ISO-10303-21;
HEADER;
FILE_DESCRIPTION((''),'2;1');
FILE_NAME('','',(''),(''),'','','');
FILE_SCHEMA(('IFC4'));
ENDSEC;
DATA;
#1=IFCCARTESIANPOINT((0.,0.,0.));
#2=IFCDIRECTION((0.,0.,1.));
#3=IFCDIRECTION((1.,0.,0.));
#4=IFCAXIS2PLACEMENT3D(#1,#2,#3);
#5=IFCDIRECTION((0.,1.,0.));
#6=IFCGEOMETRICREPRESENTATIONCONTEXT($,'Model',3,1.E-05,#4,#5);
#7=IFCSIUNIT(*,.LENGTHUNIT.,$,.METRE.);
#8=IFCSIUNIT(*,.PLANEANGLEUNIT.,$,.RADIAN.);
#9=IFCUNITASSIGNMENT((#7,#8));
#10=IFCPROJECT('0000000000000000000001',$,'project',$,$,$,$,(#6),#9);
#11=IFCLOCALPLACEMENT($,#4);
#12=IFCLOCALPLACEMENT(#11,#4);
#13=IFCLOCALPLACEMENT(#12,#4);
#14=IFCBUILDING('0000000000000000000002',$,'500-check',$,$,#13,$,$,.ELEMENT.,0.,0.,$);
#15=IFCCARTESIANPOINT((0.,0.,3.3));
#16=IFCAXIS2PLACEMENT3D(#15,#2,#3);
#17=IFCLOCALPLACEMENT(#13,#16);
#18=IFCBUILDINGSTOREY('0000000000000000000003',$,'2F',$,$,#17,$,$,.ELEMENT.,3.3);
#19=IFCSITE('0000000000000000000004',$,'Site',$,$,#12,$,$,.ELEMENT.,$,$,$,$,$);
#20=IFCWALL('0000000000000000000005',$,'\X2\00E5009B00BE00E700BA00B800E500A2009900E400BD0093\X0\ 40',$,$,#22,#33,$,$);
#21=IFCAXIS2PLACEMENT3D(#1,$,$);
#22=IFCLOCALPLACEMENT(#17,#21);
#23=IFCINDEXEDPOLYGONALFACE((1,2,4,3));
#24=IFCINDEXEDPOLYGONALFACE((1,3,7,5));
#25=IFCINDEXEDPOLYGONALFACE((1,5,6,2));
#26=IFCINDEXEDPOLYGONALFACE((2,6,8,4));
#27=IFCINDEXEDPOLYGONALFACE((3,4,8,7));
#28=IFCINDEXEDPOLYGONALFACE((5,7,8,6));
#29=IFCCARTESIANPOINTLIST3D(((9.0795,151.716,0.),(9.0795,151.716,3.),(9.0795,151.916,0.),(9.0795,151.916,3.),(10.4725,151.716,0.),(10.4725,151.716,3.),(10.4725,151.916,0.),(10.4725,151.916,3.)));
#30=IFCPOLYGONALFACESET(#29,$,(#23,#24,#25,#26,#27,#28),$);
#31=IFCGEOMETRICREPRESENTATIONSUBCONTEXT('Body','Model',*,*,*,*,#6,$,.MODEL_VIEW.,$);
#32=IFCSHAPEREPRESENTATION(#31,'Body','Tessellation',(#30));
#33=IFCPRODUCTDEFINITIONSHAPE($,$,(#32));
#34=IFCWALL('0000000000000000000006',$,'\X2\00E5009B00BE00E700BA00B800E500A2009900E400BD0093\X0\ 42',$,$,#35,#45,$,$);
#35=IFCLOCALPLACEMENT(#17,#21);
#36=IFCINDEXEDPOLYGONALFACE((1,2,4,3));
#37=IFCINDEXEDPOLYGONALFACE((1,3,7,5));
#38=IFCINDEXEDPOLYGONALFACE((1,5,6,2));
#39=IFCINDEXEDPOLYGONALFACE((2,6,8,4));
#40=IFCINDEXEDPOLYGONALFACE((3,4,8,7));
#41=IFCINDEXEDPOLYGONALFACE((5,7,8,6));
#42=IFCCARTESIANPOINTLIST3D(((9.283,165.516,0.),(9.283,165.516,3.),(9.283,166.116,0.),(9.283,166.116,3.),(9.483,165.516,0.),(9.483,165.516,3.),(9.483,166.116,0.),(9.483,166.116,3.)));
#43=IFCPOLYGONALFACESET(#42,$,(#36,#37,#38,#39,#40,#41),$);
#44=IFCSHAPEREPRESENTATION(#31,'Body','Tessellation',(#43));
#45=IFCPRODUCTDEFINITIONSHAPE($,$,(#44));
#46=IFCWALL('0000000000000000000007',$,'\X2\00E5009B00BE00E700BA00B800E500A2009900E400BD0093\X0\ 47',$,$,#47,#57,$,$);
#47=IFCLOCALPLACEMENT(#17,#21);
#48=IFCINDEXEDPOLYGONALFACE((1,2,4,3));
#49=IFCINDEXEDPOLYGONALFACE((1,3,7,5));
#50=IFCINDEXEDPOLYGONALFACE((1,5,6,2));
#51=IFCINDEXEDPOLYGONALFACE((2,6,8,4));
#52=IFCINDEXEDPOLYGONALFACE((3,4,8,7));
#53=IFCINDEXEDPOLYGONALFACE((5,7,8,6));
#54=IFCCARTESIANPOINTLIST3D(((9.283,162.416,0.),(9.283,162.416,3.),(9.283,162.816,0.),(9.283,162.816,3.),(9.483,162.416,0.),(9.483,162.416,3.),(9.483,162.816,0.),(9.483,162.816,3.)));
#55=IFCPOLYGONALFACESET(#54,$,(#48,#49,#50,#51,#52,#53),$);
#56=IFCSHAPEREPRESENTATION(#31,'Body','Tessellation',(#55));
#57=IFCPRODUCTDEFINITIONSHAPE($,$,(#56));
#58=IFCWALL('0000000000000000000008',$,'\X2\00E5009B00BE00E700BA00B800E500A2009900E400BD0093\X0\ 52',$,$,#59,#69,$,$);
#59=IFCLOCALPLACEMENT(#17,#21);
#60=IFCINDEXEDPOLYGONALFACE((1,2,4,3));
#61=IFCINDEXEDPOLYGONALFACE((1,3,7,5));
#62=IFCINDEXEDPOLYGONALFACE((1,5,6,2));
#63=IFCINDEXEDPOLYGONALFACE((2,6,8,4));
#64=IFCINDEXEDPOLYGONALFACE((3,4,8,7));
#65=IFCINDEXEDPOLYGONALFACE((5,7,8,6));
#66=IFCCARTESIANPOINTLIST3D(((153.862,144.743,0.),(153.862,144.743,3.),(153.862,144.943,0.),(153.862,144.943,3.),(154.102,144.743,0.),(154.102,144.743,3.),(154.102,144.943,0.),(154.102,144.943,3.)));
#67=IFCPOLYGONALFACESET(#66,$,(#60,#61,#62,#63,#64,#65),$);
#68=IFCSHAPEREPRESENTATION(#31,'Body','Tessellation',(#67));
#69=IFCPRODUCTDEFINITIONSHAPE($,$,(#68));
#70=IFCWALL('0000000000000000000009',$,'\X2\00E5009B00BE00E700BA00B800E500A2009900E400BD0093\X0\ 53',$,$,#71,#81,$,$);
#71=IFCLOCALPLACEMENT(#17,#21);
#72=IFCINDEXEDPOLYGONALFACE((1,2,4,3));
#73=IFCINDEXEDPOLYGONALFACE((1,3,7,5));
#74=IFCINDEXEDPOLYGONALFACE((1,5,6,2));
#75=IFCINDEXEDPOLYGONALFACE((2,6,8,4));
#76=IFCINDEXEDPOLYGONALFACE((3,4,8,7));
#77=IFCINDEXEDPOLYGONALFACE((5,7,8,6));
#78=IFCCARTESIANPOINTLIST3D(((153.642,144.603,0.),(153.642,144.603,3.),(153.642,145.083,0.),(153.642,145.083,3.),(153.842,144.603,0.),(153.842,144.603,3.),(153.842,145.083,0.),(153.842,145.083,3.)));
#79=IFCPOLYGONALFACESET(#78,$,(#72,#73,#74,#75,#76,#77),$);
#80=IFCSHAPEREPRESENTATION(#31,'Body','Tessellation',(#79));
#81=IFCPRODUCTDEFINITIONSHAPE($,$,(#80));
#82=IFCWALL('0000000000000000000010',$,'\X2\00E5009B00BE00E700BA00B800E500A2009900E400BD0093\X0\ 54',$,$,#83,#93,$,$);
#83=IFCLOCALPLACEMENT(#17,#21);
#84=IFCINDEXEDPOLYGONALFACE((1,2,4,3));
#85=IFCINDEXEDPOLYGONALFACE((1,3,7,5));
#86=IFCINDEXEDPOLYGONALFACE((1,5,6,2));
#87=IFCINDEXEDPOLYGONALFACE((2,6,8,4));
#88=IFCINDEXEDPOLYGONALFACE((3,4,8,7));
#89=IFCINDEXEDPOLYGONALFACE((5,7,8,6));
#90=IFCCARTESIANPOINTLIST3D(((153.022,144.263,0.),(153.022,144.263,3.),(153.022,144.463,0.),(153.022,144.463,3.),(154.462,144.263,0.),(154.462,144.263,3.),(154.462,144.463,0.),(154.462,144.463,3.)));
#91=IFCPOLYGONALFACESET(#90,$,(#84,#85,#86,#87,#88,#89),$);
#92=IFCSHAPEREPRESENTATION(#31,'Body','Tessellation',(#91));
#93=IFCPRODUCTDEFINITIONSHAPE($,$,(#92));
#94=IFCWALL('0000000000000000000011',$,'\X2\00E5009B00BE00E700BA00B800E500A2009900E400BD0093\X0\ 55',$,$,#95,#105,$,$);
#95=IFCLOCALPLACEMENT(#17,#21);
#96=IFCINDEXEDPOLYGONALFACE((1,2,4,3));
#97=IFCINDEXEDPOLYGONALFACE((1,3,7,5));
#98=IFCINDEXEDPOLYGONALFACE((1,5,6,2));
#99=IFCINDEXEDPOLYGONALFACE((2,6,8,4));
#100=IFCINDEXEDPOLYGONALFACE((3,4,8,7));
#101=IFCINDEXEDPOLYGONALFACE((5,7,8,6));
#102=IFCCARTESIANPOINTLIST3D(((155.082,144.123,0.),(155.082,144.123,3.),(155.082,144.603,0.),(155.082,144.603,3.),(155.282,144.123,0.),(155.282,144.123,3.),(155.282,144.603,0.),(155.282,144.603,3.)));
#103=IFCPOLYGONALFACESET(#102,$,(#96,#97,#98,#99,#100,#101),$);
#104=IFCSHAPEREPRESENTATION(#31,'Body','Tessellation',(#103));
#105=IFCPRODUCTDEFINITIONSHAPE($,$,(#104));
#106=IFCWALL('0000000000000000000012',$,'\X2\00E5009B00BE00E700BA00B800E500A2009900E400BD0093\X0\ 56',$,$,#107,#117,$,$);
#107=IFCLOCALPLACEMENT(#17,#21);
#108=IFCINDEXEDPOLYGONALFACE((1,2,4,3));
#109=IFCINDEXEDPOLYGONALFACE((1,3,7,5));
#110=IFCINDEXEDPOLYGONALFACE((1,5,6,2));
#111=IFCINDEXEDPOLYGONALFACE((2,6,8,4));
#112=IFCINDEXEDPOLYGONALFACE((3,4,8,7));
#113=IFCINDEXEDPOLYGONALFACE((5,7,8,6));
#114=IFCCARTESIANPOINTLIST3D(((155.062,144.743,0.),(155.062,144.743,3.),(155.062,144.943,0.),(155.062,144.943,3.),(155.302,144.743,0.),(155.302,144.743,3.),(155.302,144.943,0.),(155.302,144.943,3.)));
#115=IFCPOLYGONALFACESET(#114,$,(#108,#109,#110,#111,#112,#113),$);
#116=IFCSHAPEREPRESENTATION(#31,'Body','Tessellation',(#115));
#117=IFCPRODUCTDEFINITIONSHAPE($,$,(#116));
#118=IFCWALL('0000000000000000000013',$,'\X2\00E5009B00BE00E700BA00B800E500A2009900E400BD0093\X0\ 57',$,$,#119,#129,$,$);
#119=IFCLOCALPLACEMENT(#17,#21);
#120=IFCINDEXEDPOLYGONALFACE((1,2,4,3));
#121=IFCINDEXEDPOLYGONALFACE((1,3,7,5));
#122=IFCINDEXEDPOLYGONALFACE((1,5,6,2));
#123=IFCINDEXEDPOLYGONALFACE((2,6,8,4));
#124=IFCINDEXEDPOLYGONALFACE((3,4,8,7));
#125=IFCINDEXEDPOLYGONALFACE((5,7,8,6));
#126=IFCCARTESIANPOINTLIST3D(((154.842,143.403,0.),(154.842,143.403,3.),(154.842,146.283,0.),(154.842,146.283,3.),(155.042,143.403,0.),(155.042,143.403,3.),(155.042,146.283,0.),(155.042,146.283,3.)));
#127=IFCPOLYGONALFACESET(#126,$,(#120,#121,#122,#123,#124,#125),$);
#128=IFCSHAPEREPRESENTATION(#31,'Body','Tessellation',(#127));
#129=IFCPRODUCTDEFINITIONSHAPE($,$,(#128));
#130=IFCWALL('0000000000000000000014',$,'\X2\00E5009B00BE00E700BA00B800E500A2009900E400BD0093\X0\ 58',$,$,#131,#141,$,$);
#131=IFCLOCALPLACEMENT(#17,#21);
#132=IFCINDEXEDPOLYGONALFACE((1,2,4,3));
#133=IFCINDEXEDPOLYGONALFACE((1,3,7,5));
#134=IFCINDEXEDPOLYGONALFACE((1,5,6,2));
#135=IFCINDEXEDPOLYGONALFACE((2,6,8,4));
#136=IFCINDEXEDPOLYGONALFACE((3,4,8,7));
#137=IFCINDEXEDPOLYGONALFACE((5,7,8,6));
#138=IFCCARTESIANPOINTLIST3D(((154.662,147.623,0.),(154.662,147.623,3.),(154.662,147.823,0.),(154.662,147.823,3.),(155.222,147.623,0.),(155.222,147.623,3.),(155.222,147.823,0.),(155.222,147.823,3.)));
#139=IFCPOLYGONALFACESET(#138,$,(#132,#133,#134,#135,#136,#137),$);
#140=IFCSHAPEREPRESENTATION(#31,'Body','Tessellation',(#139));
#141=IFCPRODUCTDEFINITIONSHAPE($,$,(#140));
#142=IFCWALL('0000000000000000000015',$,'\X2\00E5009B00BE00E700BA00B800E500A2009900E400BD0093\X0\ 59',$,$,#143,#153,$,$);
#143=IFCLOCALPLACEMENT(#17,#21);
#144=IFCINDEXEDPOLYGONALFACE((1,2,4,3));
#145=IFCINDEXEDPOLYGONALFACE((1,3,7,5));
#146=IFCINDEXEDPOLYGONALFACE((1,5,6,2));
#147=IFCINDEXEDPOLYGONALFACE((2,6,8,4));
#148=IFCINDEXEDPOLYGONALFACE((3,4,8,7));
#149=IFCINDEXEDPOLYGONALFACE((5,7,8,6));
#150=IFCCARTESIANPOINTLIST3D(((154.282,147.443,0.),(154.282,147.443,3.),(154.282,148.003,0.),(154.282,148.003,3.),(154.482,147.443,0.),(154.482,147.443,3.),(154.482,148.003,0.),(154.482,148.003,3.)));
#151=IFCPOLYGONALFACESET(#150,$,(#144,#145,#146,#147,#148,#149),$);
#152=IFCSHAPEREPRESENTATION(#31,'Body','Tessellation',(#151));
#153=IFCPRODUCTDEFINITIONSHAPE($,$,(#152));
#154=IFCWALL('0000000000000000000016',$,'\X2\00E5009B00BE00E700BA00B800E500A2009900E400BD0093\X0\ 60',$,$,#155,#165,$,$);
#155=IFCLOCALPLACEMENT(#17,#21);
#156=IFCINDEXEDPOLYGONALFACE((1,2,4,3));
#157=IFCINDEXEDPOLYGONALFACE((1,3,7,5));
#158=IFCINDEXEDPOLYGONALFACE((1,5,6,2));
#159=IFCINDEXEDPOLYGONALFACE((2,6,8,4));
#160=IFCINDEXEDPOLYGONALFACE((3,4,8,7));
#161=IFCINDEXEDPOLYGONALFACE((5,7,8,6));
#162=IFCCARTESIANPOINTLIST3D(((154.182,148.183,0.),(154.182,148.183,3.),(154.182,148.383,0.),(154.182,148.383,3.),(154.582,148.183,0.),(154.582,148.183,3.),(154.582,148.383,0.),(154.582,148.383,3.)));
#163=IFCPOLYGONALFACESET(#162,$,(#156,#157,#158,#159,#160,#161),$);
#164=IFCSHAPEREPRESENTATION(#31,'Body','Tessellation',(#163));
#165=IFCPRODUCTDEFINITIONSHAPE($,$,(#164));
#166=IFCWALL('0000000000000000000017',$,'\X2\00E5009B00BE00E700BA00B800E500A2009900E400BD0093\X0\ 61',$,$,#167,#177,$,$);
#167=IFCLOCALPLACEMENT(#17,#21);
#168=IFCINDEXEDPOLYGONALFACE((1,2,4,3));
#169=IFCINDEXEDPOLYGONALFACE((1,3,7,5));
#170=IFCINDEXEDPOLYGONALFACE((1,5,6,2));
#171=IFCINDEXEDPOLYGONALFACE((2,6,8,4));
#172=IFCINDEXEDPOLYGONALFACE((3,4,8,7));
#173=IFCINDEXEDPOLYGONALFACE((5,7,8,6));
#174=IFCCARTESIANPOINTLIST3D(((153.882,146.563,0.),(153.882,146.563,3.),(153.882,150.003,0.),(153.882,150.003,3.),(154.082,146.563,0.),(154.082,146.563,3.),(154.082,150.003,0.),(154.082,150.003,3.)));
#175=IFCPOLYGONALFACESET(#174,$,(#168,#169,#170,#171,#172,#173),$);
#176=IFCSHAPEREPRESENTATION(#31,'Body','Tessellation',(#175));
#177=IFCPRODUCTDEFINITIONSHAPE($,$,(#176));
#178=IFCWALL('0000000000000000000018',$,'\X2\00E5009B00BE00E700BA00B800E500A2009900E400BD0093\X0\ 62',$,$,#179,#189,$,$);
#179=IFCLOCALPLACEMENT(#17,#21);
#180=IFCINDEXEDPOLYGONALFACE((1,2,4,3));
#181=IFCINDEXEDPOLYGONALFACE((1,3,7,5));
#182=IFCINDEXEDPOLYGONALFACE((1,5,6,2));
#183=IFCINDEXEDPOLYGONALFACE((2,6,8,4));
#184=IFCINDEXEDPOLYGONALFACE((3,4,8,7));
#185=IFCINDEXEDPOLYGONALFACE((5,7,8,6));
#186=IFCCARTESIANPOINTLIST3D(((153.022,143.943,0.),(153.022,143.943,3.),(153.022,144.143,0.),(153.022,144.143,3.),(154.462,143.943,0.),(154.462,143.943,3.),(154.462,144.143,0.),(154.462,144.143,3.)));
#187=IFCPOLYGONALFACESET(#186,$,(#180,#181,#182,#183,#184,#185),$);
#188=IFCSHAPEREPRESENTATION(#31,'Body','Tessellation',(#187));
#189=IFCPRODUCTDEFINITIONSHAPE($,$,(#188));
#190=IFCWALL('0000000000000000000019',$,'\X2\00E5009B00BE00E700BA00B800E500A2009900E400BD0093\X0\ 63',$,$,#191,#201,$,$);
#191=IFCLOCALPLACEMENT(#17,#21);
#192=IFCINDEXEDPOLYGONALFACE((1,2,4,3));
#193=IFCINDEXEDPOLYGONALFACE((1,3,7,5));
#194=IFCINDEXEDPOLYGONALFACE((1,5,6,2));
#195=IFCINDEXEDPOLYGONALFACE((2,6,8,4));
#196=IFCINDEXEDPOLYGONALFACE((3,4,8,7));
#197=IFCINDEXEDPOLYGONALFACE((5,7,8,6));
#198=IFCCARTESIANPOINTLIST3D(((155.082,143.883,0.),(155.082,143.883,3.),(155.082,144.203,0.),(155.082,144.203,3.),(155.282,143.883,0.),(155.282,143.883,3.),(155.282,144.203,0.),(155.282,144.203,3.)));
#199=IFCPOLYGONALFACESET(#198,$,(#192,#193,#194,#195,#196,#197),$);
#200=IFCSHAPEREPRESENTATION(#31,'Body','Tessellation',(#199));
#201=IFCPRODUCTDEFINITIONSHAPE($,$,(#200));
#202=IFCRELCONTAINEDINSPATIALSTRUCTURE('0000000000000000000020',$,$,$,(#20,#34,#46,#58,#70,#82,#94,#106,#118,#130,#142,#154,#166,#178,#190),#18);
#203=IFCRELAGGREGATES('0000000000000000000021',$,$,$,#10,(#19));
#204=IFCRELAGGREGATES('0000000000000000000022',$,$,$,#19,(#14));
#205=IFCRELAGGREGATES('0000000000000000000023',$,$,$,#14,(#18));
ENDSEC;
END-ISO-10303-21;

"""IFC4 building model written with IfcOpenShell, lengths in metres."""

from ifc_helpers import new_model, si_unit, direction, frame, frame_2d, origin_with_axes, place, context, subcontext, project, spatial, rectangle, extrude, element, save


model = new_model("IFC4")

# Units and contexts
model_context = context("Model", 3, precision=1e-05, world=origin_with_axes(), true_north=direction((0.0, 1.0, 0.0)))
body_context = subcontext(model_context, "Body", "Model", "MODEL_VIEW")
ifc_project = project(units=[si_unit("LENGTHUNIT", "METRE"), si_unit("PLANEANGLEUNIT", "RADIAN")], contexts=[model_context])

# Site, building, storey
placement = place(None, origin_with_axes())
site_placement = place(placement, origin_with_axes())
site = spatial("IfcSite", under=ifc_project, at=site_placement, Name="Site", CompositionType="ELEMENT")
building_placement = place(site_placement, origin_with_axes())
building = spatial("IfcBuilding", under=site, at=building_placement, Name="500-check", CompositionType="ELEMENT", ElevationOfRefHeight=0.0, ElevationOfTerrain=0.0)
storey_placement = place(building_placement, frame((0.0, 0.0, 3.3), z_axis=(0.0, 0.0, 1.0), x_axis=(1.0, 0.0, 0.0)))
storey = spatial("IfcBuildingStorey", under=building, at=storey_placement, Name="2F", CompositionType="ELEMENT", Elevation=3.3)

# Walls
wall_1_placement = place(storey_placement, frame((9.776, 151.816, 0.0), z_axis=(0.0, 0.0, 1.0), x_axis=(-1.0, 0.0, 0.0)))
element("IfcWall", 1, at=wall_1_placement, inside=storey, Name="å\u009b¾çº¸å¢\u0099ä½\u0093 40", context=body_context, shape_type="SweptSolid", body=[
    extrude(rectangle(XDim=1.393, YDim=0.2, at=frame_2d((0.0, 0.0), x_axis=(1.0, 0.0, 0.0))), frame((0.0, 0.0, 0.0), z_axis=(0.0, 0.0, 1.0)), (0.0, 0.0, 1.0), 3.0),
])
wall_2_placement = place(storey_placement, frame((9.383, 165.816, 0.0), z_axis=(0.0, 0.0, 1.0), x_axis=(0.0, 1.0, 0.0)))
element("IfcWall", 2, at=wall_2_placement, inside=storey, Name="å\u009b¾çº¸å¢\u0099ä½\u0093 42", context=body_context, shape_type="SweptSolid", body=[
    extrude(rectangle(XDim=0.6, YDim=0.2, at=frame_2d((0.0, 0.0), x_axis=(1.0, 0.0, 0.0))), frame((0.0, 0.0, 0.0), z_axis=(0.0, 0.0, 1.0)), (0.0, 0.0, 1.0), 3.0),
])
wall_3_placement = place(storey_placement, frame((9.383, 162.616, 0.0), z_axis=(0.0, 0.0, 1.0), x_axis=(0.0, -1.0, 0.0)))
element("IfcWall", 3, at=wall_3_placement, inside=storey, Name="å\u009b¾çº¸å¢\u0099ä½\u0093 47", context=body_context, shape_type="SweptSolid", body=[
    extrude(rectangle(XDim=0.4, YDim=0.2, at=frame_2d((0.0, 0.0), x_axis=(1.0, 0.0, 0.0))), frame((0.0, 0.0, 0.0), z_axis=(0.0, 0.0, 1.0)), (0.0, 0.0, 1.0), 3.0),
])
wall_4_placement = place(storey_placement, frame((153.982, 144.843, 0.0), z_axis=(0.0, 0.0, 1.0), x_axis=(-1.0, 0.0, 0.0)))
element("IfcWall", 4, at=wall_4_placement, inside=storey, Name="å\u009b¾çº¸å¢\u0099ä½\u0093 52", context=body_context, shape_type="SweptSolid", body=[
    extrude(rectangle(XDim=0.24, YDim=0.2, at=frame_2d((0.0, 0.0), x_axis=(1.0, 0.0, 0.0))), frame((0.0, 0.0, 0.0), z_axis=(0.0, 0.0, 1.0)), (0.0, 0.0, 1.0), 3.0),
])
wall_5_placement = place(storey_placement, frame((153.742, 144.843, 0.0), z_axis=(0.0, 0.0, 1.0), x_axis=(0.0, -1.0, 0.0)))
element("IfcWall", 5, at=wall_5_placement, inside=storey, Name="å\u009b¾çº¸å¢\u0099ä½\u0093 53", context=body_context, shape_type="SweptSolid", body=[
    extrude(rectangle(XDim=0.48, YDim=0.2, at=frame_2d((0.0, 0.0), x_axis=(1.0, 0.0, 0.0))), frame((0.0, 0.0, 0.0), z_axis=(0.0, 0.0, 1.0)), (0.0, 0.0, 1.0), 3.0),
])
wall_6_placement = place(storey_placement, frame((153.742, 144.363, 0.0), z_axis=(0.0, 0.0, 1.0), x_axis=(1.0, 0.0, 0.0)))
element("IfcWall", 6, at=wall_6_placement, inside=storey, Name="å\u009b¾çº¸å¢\u0099ä½\u0093 54", context=body_context, shape_type="SweptSolid", body=[
    extrude(rectangle(XDim=1.44, YDim=0.2, at=frame_2d((0.0, 0.0), x_axis=(1.0, 0.0, 0.0))), frame((0.0, 0.0, 0.0), z_axis=(0.0, 0.0, 1.0)), (0.0, 0.0, 1.0), 3.0),
])
wall_7_placement = place(storey_placement, frame((155.182, 144.363, 0.0), z_axis=(0.0, 0.0, 1.0), x_axis=(0.0, 1.0, 0.0)))
element("IfcWall", 7, at=wall_7_placement, inside=storey, Name="å\u009b¾çº¸å¢\u0099ä½\u0093 55", context=body_context, shape_type="SweptSolid", body=[
    extrude(rectangle(XDim=0.48, YDim=0.2, at=frame_2d((0.0, 0.0), x_axis=(1.0, 0.0, 0.0))), frame((0.0, 0.0, 0.0), z_axis=(0.0, 0.0, 1.0)), (0.0, 0.0, 1.0), 3.0),
])
wall_8_placement = place(storey_placement, frame((155.182, 144.843, 0.0), z_axis=(0.0, 0.0, 1.0), x_axis=(-1.0, 0.0, 0.0)))
element("IfcWall", 8, at=wall_8_placement, inside=storey, Name="å\u009b¾çº¸å¢\u0099ä½\u0093 56", context=body_context, shape_type="SweptSolid", body=[
    extrude(rectangle(XDim=0.24, YDim=0.2, at=frame_2d((0.0, 0.0), x_axis=(1.0, 0.0, 0.0))), frame((0.0, 0.0, 0.0), z_axis=(0.0, 0.0, 1.0)), (0.0, 0.0, 1.0), 3.0),
])
wall_9_placement = place(storey_placement, frame((154.942, 144.843, 0.0), z_axis=(0.0, 0.0, 1.0), x_axis=(0.0, 1.0, 0.0)))
element("IfcWall", 9, at=wall_9_placement, inside=storey, Name="å\u009b¾çº¸å¢\u0099ä½\u0093 57", context=body_context, shape_type="SweptSolid", body=[
    extrude(rectangle(XDim=2.88, YDim=0.2, at=frame_2d((0.0, 0.0), x_axis=(1.0, 0.0, 0.0))), frame((0.0, 0.0, 0.0), z_axis=(0.0, 0.0, 1.0)), (0.0, 0.0, 1.0), 3.0),
])
for number, where, z_axis, x_axis, name in (
    (10, (154.942, 147.723, 0.0), (0.0, 0.0, 1.0), (-1.0, 0.0, 0.0), "å\u009b¾çº¸å¢\u0099ä½\u0093 58"),
    (11, (154.382, 147.723, 0.0), (0.0, 0.0, 1.0), (0.0, 1.0, 0.0), "å\u009b¾çº¸å¢\u0099ä½\u0093 59"),
):
    element("IfcWall", number, at=place(storey_placement, frame(where, z_axis=z_axis, x_axis=x_axis)), inside=storey, Name=name, context=body_context, shape_type="SweptSolid", body=[
        extrude(rectangle(XDim=0.56, YDim=0.2, at=frame_2d((0.0, 0.0), x_axis=(1.0, 0.0, 0.0))), frame((0.0, 0.0, 0.0), z_axis=(0.0, 0.0, 1.0)), (0.0, 0.0, 1.0), 3.0),
    ])
wall_10_placement = place(storey_placement, frame((154.382, 148.283, 0.0), z_axis=(0.0, 0.0, 1.0), x_axis=(-1.0, 0.0, 0.0)))
element("IfcWall", 12, at=wall_10_placement, inside=storey, Name="å\u009b¾çº¸å¢\u0099ä½\u0093 60", context=body_context, shape_type="SweptSolid", body=[
    extrude(rectangle(XDim=0.4, YDim=0.2, at=frame_2d((0.0, 0.0), x_axis=(1.0, 0.0, 0.0))), frame((0.0, 0.0, 0.0), z_axis=(0.0, 0.0, 1.0)), (0.0, 0.0, 1.0), 3.0),
])
wall_11_placement = place(storey_placement, frame((153.982, 148.283, 0.0), z_axis=(0.0, 0.0, 1.0), x_axis=(0.0, -1.0, 0.0)))
element("IfcWall", 13, at=wall_11_placement, inside=storey, Name="å\u009b¾çº¸å¢\u0099ä½\u0093 61", context=body_context, shape_type="SweptSolid", body=[
    extrude(rectangle(XDim=3.44, YDim=0.2, at=frame_2d((0.0, 0.0), x_axis=(1.0, 0.0, 0.0))), frame((0.0, 0.0, 0.0), z_axis=(0.0, 0.0, 1.0)), (0.0, 0.0, 1.0), 3.0),
])
wall_12_placement = place(storey_placement, frame((153.742, 144.043, 0.0), z_axis=(0.0, 0.0, 1.0), x_axis=(1.0, 0.0, 0.0)))
element("IfcWall", 14, at=wall_12_placement, inside=storey, Name="å\u009b¾çº¸å¢\u0099ä½\u0093 62", context=body_context, shape_type="SweptSolid", body=[
    extrude(rectangle(XDim=1.44, YDim=0.2, at=frame_2d((0.0, 0.0), x_axis=(1.0, 0.0, 0.0))), frame((0.0, 0.0, 0.0), z_axis=(0.0, 0.0, 1.0)), (0.0, 0.0, 1.0), 3.0),
])
wall_13_placement = place(storey_placement, frame((155.182, 144.043, 0.0), z_axis=(0.0, 0.0, 1.0), x_axis=(0.0, 1.0, 0.0)))
element("IfcWall", 15, at=wall_13_placement, inside=storey, Name="å\u009b¾çº¸å¢\u0099ä½\u0093 63", context=body_context, shape_type="SweptSolid", body=[
    extrude(rectangle(XDim=0.32, YDim=0.2, at=frame_2d((0.0, 0.0), x_axis=(1.0, 0.0, 0.0))), frame((0.0, 0.0, 0.0), z_axis=(0.0, 0.0, 1.0)), (0.0, 0.0, 1.0), 3.0),
])

save(model, "model.ifc")
